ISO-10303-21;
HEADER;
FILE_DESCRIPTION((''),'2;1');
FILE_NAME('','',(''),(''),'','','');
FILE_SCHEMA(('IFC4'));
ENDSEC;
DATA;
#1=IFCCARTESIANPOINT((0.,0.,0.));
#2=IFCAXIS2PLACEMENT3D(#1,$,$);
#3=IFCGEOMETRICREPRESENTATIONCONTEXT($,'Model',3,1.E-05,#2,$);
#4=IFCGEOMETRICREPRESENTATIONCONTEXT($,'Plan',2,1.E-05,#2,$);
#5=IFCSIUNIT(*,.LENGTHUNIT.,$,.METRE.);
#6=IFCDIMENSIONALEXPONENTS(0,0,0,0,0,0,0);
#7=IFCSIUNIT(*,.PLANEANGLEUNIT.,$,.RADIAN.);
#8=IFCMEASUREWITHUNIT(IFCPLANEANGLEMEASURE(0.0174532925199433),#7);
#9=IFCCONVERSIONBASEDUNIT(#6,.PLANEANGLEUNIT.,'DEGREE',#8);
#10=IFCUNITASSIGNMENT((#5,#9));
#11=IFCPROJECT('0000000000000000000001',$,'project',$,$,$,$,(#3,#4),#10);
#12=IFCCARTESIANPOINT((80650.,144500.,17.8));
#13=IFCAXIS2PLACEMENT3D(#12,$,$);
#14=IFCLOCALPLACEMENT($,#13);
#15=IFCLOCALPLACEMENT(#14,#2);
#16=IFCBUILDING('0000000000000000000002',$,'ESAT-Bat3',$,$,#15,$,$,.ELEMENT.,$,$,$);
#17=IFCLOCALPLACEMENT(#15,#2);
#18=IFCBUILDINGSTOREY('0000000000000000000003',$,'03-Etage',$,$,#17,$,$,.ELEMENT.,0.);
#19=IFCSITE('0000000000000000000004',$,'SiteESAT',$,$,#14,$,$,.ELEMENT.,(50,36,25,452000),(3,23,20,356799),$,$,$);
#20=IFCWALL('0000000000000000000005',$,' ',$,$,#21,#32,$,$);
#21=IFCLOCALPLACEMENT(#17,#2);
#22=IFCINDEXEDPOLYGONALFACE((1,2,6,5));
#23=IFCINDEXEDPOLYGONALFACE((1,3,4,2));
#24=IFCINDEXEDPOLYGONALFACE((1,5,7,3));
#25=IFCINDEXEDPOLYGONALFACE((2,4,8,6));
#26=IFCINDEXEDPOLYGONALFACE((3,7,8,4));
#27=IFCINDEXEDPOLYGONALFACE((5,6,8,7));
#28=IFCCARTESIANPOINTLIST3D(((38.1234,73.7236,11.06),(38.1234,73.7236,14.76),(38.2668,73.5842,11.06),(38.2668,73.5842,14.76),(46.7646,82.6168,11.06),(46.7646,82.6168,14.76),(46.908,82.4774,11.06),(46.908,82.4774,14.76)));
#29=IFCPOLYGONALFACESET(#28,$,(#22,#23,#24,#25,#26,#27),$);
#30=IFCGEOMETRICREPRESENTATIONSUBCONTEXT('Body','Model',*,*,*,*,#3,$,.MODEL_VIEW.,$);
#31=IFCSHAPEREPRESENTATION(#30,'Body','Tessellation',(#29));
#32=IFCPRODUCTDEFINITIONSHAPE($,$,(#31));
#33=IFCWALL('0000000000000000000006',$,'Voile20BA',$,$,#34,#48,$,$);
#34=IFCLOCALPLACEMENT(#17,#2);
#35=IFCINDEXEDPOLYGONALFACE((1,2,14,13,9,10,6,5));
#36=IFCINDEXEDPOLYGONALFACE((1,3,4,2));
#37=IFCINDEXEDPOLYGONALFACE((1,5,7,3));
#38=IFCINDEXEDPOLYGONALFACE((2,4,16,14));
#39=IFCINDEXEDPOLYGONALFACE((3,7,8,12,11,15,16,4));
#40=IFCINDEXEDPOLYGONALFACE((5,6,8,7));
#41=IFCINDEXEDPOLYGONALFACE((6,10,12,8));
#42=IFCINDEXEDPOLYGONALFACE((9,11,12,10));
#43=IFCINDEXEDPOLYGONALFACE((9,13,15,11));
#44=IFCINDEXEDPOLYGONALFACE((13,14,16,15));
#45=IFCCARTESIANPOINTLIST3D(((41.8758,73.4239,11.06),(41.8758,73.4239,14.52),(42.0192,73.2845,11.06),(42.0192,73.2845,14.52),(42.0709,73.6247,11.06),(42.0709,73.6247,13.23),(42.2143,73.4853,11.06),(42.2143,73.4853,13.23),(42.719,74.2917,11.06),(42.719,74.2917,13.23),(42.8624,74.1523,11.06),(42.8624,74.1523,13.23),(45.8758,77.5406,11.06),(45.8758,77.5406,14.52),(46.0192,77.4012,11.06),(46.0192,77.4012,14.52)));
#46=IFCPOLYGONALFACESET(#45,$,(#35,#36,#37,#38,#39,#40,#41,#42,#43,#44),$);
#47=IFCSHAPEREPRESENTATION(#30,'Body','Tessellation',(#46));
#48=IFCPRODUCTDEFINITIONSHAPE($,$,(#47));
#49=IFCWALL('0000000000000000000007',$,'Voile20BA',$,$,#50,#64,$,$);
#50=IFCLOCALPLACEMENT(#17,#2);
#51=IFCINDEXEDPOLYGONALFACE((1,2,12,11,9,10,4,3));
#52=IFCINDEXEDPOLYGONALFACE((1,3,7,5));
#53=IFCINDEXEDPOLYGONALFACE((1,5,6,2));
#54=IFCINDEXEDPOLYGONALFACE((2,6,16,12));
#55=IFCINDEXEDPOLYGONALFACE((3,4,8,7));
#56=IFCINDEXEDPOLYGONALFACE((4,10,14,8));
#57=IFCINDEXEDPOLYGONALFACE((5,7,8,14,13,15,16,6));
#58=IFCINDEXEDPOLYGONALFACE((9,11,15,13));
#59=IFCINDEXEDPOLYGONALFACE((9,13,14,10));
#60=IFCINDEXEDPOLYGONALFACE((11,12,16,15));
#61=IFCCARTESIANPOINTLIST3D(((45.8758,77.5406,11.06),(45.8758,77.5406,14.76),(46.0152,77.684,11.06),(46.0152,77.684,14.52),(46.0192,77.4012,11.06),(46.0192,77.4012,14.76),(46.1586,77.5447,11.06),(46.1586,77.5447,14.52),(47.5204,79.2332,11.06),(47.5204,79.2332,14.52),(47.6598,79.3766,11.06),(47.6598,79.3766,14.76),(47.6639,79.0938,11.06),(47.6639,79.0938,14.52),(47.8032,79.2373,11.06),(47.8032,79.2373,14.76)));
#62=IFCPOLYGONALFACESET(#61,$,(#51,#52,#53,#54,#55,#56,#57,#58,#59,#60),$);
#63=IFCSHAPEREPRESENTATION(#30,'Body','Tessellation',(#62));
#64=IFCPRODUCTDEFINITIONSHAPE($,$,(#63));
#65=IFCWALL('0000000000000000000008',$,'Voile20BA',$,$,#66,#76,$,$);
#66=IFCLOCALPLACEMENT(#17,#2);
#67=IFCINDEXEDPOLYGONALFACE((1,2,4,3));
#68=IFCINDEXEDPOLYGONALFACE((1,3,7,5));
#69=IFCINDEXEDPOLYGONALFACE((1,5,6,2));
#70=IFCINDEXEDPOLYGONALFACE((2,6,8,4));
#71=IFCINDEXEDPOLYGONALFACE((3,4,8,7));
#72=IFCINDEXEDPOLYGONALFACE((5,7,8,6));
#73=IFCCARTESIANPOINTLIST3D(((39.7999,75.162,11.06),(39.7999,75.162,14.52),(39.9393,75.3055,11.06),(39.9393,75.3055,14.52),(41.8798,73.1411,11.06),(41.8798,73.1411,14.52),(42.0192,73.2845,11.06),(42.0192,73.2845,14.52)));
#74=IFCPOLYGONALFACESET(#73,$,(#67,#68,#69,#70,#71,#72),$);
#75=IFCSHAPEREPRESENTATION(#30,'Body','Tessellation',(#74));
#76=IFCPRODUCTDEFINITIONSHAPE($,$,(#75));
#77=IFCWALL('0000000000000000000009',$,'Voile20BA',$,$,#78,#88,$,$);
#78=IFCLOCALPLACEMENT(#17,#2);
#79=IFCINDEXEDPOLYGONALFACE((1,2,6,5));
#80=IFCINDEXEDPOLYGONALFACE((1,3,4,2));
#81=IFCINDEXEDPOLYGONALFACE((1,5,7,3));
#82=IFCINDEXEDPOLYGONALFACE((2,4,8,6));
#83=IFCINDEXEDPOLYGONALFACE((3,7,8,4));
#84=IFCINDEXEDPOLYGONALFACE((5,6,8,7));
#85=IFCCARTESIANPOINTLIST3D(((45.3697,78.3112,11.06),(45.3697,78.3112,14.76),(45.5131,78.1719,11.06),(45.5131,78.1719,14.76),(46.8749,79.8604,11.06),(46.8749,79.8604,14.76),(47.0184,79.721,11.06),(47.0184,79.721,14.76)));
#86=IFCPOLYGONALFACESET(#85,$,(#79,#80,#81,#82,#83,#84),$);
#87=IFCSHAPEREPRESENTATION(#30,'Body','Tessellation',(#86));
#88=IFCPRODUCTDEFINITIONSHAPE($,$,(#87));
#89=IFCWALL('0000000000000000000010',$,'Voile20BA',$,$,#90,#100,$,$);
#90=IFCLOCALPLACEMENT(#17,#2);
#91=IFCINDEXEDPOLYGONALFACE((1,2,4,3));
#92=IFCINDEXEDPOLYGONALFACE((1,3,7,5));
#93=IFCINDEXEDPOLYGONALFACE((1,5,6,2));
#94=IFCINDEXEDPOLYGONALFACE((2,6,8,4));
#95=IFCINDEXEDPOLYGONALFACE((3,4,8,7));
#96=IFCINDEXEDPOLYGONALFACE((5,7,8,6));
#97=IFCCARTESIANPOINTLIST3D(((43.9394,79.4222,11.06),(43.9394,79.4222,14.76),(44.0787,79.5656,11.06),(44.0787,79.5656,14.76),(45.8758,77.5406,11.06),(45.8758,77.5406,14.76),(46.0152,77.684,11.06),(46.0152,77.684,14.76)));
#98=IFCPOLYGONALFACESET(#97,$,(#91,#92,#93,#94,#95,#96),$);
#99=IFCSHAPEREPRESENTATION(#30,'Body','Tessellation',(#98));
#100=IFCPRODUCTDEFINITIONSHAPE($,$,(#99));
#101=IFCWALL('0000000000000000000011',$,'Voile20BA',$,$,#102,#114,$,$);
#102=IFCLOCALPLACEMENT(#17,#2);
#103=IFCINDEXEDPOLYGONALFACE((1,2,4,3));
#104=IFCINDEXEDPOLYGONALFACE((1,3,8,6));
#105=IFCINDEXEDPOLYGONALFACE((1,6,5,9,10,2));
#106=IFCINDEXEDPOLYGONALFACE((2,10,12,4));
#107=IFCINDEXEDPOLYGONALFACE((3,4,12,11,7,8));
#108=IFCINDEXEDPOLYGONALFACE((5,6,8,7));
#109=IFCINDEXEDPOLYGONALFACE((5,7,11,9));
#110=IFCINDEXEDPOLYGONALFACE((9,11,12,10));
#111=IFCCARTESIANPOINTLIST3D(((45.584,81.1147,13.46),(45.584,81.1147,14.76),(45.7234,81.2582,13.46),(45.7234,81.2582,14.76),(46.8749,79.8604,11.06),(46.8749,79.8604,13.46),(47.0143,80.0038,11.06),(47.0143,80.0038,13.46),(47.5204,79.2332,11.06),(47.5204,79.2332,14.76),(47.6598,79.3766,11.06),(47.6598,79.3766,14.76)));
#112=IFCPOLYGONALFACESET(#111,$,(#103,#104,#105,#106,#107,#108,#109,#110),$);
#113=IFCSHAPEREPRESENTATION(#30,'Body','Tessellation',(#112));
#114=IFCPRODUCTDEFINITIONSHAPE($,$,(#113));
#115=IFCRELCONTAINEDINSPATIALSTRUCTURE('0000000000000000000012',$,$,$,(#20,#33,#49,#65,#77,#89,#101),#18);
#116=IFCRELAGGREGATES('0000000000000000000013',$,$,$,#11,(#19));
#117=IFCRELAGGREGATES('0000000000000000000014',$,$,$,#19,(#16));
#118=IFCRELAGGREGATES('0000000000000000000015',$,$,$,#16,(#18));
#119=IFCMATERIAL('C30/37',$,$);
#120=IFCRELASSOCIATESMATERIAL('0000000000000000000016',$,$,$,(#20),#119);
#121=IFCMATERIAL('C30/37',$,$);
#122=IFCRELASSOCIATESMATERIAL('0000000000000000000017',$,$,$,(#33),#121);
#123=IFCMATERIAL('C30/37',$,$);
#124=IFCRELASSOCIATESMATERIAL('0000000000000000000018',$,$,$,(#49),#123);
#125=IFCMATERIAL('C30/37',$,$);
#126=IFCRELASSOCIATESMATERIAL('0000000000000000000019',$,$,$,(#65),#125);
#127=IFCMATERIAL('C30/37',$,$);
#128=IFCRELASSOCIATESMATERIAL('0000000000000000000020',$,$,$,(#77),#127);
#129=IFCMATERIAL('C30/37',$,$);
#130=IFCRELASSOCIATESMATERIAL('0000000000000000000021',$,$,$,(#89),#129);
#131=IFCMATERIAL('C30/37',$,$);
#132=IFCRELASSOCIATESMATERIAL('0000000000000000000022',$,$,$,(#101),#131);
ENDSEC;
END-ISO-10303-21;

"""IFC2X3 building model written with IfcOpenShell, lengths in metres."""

from ifc_helpers import new_model, entity, si_unit, converted_unit, frame, frame_2d, origin, origin_with_axes, place, context, subcontext, project, spatial, polyline, rectangle, outline, extrude, material, element, save


model = new_model("IFC2X3")

# Units and contexts
model_context = context("Model", 3, precision=1e-05, world=origin())
plan_context = context("Plan", 2, precision=1e-05, world=origin())
body_context = subcontext(model_context, "Body", "Model", "MODEL_VIEW")
ifc_project = project(units=[si_unit("LENGTHUNIT", "METRE"), converted_unit("PLANEANGLEUNIT", "DEGREE", entity("IfcPlaneAngleMeasure", 0.0174532925199433), si_unit("PLANEANGLEUNIT", "RADIAN"), dimensions=[0, 0, 0, 0, 0, 0, 0])], contexts=[model_context, plan_context])

# Site, building, storey
site_placement = place(None, frame((80650.0, 144500.0, 17.8)))
site = spatial("IfcSite", under=ifc_project, at=site_placement, Name="SiteESAT", CompositionType="ELEMENT", RefLatitude=(50, 36, 25, 452000), RefLongitude=(3, 23, 20, 356799))
building_placement = place(site_placement, origin())
building = spatial("IfcBuilding", under=site, at=building_placement, Name="ESAT-Bat3", CompositionType="ELEMENT")
storey_placement = place(building_placement, origin())
storey = spatial("IfcBuildingStorey", under=building, at=storey_placement, Name="03-Etage", CompositionType="ELEMENT", Elevation=0.0)

# Wall
ifc_material_1 = material(Name="C30/37")
wall_1_placement = place(storey_placement, frame((46.7646, 82.6168, 11.06), z_axis=(0.0, 0.0, 1.0), x_axis=(-0.696872, -0.717196, 0.0)))
element("IfcWall", 1, at=wall_1_placement, inside=storey, material=ifc_material_1, Name=" ", context=body_context, shape_type="SweptSolid", body=[
    extrude(rectangle(XDim=12.4, YDim=0.2, at=frame_2d((6.2, 0.1), x_axis=(1.0, 0.0))), origin_with_axes(), (0.0, 0.0, 1.0), 3.7),
])

# Walls, openings
ifc_material_2 = material(Name="C30/37")
wall_2_placement = place(storey_placement, frame((45.8758, 77.5406, 11.06), z_axis=(0.0, 0.0, 1.0), x_axis=(-0.696872, -0.717196, 0.0)))
wall_2 = element("IfcWall", 2, at=wall_2_placement, inside=storey, material=ifc_material_2, Name="Voile20BA", context=body_context, shape_type="SweptSolid", body=[
    extrude(rectangle(XDim=5.74, YDim=0.2, at=frame_2d((2.87, 0.1), x_axis=(1.0, 0.0))), origin_with_axes(), (0.0, 0.0, 1.0), 3.46),
])
opening_1_placement = place(wall_2_placement, frame((5.46, 0.2, 0.0), z_axis=(0.0, -1.0, 0.0), x_axis=(0.0, 0.0, 1.0)))
element("IfcOpeningElement", 3, at=opening_1_placement, cuts=wall_2, ObjectType="Opening", context=body_context, shape_type="SweptSolid", body=[
    extrude(outline(polyline([(0.0, 0.93), (2.17, 0.93), (2.17, 0.0), (0.0, 0.0), (0.0, 0.93)])), origin_with_axes(), (0.0, 0.0, 1.0), 0.2),
])
ifc_material_3 = material(Name="C30/37")
wall_3_placement = place(storey_placement, frame((47.6598, 79.3766, 11.06), z_axis=(0.0, 0.0, 1.0), x_axis=(-0.696872, -0.717196, 0.0)))
wall_3 = element("IfcWall", 4, at=wall_3_placement, inside=storey, material=ifc_material_3, Name="Voile20BA", context=body_context, shape_type="SweptSolid", body=[
    extrude(rectangle(XDim=2.56, YDim=0.2, at=frame_2d((1.28, 0.1), x_axis=(1.0, 0.0))), origin_with_axes(), (0.0, 0.0, 1.0), 3.7),
])
opening_2_placement = place(wall_3_placement, frame((2.36, 0.2, 0.0), z_axis=(0.0, -1.0, 0.0), x_axis=(0.0, 0.0, 1.0)))
element("IfcOpeningElement", 5, at=opening_2_placement, cuts=wall_3, ObjectType="Opening", context=body_context, shape_type="SweptSolid", body=[
    extrude(outline(polyline([(0.0, 2.16), (3.46, 2.16), (3.46, 0.0), (0.0, 0.0), (0.0, 2.16)])), origin_with_axes(), (0.0, 0.0, 1.0), 0.2),
])

# Walls
ifc_material_4 = material(Name="C30/37")
wall_4_placement = place(storey_placement, frame((39.7999, 75.162, 11.06), z_axis=(0.0, 0.0, 1.0), x_axis=(0.717196, -0.696872, 0.0)))
element("IfcWall", 6, at=wall_4_placement, inside=storey, material=ifc_material_4, Name="Voile20BA", context=body_context, shape_type="SweptSolid", body=[
    extrude(rectangle(XDim=2.9, YDim=0.2, at=frame_2d((1.45, 0.1), x_axis=(1.0, 0.0))), origin_with_axes(), (0.0, 0.0, 1.0), 3.46),
])
ifc_material_5 = material(Name="C30/37")
wall_5_placement = place(storey_placement, frame((46.8749, 79.8604, 11.06), z_axis=(0.0, 0.0, 1.0), x_axis=(-0.696872, -0.717196, 0.0)))
element("IfcWall", 7, at=wall_5_placement, inside=storey, material=ifc_material_5, Name="Voile20BA", context=body_context, shape_type="SweptSolid", body=[
    extrude(rectangle(XDim=2.16, YDim=0.2, at=frame_2d((1.08, 0.1), x_axis=(1.0, 0.0))), origin_with_axes(), (0.0, 0.0, 1.0), 3.7),
])
ifc_material_6 = material(Name="C30/37")
wall_6_placement = place(storey_placement, frame((46.0152, 77.684, 11.06), z_axis=(0.0, 0.0, 1.0), x_axis=(-0.717196, 0.696872, 0.0)))
element("IfcWall", 8, at=wall_6_placement, inside=storey, material=ifc_material_6, Name="Voile20BA", context=body_context, shape_type="SweptSolid", body=[
    extrude(rectangle(XDim=2.7, YDim=0.2, at=frame_2d((1.35, 0.1), x_axis=(1.0, 0.0))), origin_with_axes(), (0.0, 0.0, 1.0), 3.7),
])

# Wall, opening
ifc_material_7 = material(Name="C30/37")
wall_7_placement = place(storey_placement, frame((45.584, 81.1147, 11.06), z_axis=(0.0, 0.0, 1.0), x_axis=(0.717196, -0.696872, 0.0)))
wall_7 = element("IfcWall", 9, at=wall_7_placement, inside=storey, material=ifc_material_7, Name="Voile20BA", context=body_context, shape_type="SweptSolid", body=[
    extrude(rectangle(XDim=2.7, YDim=0.2, at=frame_2d((1.35, 0.1), x_axis=(1.0, 0.0))), origin_with_axes(), (0.0, 0.0, 1.0), 3.7),
])
opening_3_placement = place(wall_7_placement, frame((1.8, 0.2, 0.0), z_axis=(0.0, -1.0, 0.0), x_axis=(0.0, 0.0, 1.0)))
element("IfcOpeningElement", 10, at=opening_3_placement, cuts=wall_7, ObjectType="Opening", context=body_context, shape_type="SweptSolid", body=[
    extrude(outline(polyline([(0.0, 1.8), (2.4, 1.8), (2.4, 0.0), (0.0, 0.0), (0.0, 1.8)])), origin_with_axes(), (0.0, 0.0, 1.0), 0.2),
])

save(model, "model.ifc")
